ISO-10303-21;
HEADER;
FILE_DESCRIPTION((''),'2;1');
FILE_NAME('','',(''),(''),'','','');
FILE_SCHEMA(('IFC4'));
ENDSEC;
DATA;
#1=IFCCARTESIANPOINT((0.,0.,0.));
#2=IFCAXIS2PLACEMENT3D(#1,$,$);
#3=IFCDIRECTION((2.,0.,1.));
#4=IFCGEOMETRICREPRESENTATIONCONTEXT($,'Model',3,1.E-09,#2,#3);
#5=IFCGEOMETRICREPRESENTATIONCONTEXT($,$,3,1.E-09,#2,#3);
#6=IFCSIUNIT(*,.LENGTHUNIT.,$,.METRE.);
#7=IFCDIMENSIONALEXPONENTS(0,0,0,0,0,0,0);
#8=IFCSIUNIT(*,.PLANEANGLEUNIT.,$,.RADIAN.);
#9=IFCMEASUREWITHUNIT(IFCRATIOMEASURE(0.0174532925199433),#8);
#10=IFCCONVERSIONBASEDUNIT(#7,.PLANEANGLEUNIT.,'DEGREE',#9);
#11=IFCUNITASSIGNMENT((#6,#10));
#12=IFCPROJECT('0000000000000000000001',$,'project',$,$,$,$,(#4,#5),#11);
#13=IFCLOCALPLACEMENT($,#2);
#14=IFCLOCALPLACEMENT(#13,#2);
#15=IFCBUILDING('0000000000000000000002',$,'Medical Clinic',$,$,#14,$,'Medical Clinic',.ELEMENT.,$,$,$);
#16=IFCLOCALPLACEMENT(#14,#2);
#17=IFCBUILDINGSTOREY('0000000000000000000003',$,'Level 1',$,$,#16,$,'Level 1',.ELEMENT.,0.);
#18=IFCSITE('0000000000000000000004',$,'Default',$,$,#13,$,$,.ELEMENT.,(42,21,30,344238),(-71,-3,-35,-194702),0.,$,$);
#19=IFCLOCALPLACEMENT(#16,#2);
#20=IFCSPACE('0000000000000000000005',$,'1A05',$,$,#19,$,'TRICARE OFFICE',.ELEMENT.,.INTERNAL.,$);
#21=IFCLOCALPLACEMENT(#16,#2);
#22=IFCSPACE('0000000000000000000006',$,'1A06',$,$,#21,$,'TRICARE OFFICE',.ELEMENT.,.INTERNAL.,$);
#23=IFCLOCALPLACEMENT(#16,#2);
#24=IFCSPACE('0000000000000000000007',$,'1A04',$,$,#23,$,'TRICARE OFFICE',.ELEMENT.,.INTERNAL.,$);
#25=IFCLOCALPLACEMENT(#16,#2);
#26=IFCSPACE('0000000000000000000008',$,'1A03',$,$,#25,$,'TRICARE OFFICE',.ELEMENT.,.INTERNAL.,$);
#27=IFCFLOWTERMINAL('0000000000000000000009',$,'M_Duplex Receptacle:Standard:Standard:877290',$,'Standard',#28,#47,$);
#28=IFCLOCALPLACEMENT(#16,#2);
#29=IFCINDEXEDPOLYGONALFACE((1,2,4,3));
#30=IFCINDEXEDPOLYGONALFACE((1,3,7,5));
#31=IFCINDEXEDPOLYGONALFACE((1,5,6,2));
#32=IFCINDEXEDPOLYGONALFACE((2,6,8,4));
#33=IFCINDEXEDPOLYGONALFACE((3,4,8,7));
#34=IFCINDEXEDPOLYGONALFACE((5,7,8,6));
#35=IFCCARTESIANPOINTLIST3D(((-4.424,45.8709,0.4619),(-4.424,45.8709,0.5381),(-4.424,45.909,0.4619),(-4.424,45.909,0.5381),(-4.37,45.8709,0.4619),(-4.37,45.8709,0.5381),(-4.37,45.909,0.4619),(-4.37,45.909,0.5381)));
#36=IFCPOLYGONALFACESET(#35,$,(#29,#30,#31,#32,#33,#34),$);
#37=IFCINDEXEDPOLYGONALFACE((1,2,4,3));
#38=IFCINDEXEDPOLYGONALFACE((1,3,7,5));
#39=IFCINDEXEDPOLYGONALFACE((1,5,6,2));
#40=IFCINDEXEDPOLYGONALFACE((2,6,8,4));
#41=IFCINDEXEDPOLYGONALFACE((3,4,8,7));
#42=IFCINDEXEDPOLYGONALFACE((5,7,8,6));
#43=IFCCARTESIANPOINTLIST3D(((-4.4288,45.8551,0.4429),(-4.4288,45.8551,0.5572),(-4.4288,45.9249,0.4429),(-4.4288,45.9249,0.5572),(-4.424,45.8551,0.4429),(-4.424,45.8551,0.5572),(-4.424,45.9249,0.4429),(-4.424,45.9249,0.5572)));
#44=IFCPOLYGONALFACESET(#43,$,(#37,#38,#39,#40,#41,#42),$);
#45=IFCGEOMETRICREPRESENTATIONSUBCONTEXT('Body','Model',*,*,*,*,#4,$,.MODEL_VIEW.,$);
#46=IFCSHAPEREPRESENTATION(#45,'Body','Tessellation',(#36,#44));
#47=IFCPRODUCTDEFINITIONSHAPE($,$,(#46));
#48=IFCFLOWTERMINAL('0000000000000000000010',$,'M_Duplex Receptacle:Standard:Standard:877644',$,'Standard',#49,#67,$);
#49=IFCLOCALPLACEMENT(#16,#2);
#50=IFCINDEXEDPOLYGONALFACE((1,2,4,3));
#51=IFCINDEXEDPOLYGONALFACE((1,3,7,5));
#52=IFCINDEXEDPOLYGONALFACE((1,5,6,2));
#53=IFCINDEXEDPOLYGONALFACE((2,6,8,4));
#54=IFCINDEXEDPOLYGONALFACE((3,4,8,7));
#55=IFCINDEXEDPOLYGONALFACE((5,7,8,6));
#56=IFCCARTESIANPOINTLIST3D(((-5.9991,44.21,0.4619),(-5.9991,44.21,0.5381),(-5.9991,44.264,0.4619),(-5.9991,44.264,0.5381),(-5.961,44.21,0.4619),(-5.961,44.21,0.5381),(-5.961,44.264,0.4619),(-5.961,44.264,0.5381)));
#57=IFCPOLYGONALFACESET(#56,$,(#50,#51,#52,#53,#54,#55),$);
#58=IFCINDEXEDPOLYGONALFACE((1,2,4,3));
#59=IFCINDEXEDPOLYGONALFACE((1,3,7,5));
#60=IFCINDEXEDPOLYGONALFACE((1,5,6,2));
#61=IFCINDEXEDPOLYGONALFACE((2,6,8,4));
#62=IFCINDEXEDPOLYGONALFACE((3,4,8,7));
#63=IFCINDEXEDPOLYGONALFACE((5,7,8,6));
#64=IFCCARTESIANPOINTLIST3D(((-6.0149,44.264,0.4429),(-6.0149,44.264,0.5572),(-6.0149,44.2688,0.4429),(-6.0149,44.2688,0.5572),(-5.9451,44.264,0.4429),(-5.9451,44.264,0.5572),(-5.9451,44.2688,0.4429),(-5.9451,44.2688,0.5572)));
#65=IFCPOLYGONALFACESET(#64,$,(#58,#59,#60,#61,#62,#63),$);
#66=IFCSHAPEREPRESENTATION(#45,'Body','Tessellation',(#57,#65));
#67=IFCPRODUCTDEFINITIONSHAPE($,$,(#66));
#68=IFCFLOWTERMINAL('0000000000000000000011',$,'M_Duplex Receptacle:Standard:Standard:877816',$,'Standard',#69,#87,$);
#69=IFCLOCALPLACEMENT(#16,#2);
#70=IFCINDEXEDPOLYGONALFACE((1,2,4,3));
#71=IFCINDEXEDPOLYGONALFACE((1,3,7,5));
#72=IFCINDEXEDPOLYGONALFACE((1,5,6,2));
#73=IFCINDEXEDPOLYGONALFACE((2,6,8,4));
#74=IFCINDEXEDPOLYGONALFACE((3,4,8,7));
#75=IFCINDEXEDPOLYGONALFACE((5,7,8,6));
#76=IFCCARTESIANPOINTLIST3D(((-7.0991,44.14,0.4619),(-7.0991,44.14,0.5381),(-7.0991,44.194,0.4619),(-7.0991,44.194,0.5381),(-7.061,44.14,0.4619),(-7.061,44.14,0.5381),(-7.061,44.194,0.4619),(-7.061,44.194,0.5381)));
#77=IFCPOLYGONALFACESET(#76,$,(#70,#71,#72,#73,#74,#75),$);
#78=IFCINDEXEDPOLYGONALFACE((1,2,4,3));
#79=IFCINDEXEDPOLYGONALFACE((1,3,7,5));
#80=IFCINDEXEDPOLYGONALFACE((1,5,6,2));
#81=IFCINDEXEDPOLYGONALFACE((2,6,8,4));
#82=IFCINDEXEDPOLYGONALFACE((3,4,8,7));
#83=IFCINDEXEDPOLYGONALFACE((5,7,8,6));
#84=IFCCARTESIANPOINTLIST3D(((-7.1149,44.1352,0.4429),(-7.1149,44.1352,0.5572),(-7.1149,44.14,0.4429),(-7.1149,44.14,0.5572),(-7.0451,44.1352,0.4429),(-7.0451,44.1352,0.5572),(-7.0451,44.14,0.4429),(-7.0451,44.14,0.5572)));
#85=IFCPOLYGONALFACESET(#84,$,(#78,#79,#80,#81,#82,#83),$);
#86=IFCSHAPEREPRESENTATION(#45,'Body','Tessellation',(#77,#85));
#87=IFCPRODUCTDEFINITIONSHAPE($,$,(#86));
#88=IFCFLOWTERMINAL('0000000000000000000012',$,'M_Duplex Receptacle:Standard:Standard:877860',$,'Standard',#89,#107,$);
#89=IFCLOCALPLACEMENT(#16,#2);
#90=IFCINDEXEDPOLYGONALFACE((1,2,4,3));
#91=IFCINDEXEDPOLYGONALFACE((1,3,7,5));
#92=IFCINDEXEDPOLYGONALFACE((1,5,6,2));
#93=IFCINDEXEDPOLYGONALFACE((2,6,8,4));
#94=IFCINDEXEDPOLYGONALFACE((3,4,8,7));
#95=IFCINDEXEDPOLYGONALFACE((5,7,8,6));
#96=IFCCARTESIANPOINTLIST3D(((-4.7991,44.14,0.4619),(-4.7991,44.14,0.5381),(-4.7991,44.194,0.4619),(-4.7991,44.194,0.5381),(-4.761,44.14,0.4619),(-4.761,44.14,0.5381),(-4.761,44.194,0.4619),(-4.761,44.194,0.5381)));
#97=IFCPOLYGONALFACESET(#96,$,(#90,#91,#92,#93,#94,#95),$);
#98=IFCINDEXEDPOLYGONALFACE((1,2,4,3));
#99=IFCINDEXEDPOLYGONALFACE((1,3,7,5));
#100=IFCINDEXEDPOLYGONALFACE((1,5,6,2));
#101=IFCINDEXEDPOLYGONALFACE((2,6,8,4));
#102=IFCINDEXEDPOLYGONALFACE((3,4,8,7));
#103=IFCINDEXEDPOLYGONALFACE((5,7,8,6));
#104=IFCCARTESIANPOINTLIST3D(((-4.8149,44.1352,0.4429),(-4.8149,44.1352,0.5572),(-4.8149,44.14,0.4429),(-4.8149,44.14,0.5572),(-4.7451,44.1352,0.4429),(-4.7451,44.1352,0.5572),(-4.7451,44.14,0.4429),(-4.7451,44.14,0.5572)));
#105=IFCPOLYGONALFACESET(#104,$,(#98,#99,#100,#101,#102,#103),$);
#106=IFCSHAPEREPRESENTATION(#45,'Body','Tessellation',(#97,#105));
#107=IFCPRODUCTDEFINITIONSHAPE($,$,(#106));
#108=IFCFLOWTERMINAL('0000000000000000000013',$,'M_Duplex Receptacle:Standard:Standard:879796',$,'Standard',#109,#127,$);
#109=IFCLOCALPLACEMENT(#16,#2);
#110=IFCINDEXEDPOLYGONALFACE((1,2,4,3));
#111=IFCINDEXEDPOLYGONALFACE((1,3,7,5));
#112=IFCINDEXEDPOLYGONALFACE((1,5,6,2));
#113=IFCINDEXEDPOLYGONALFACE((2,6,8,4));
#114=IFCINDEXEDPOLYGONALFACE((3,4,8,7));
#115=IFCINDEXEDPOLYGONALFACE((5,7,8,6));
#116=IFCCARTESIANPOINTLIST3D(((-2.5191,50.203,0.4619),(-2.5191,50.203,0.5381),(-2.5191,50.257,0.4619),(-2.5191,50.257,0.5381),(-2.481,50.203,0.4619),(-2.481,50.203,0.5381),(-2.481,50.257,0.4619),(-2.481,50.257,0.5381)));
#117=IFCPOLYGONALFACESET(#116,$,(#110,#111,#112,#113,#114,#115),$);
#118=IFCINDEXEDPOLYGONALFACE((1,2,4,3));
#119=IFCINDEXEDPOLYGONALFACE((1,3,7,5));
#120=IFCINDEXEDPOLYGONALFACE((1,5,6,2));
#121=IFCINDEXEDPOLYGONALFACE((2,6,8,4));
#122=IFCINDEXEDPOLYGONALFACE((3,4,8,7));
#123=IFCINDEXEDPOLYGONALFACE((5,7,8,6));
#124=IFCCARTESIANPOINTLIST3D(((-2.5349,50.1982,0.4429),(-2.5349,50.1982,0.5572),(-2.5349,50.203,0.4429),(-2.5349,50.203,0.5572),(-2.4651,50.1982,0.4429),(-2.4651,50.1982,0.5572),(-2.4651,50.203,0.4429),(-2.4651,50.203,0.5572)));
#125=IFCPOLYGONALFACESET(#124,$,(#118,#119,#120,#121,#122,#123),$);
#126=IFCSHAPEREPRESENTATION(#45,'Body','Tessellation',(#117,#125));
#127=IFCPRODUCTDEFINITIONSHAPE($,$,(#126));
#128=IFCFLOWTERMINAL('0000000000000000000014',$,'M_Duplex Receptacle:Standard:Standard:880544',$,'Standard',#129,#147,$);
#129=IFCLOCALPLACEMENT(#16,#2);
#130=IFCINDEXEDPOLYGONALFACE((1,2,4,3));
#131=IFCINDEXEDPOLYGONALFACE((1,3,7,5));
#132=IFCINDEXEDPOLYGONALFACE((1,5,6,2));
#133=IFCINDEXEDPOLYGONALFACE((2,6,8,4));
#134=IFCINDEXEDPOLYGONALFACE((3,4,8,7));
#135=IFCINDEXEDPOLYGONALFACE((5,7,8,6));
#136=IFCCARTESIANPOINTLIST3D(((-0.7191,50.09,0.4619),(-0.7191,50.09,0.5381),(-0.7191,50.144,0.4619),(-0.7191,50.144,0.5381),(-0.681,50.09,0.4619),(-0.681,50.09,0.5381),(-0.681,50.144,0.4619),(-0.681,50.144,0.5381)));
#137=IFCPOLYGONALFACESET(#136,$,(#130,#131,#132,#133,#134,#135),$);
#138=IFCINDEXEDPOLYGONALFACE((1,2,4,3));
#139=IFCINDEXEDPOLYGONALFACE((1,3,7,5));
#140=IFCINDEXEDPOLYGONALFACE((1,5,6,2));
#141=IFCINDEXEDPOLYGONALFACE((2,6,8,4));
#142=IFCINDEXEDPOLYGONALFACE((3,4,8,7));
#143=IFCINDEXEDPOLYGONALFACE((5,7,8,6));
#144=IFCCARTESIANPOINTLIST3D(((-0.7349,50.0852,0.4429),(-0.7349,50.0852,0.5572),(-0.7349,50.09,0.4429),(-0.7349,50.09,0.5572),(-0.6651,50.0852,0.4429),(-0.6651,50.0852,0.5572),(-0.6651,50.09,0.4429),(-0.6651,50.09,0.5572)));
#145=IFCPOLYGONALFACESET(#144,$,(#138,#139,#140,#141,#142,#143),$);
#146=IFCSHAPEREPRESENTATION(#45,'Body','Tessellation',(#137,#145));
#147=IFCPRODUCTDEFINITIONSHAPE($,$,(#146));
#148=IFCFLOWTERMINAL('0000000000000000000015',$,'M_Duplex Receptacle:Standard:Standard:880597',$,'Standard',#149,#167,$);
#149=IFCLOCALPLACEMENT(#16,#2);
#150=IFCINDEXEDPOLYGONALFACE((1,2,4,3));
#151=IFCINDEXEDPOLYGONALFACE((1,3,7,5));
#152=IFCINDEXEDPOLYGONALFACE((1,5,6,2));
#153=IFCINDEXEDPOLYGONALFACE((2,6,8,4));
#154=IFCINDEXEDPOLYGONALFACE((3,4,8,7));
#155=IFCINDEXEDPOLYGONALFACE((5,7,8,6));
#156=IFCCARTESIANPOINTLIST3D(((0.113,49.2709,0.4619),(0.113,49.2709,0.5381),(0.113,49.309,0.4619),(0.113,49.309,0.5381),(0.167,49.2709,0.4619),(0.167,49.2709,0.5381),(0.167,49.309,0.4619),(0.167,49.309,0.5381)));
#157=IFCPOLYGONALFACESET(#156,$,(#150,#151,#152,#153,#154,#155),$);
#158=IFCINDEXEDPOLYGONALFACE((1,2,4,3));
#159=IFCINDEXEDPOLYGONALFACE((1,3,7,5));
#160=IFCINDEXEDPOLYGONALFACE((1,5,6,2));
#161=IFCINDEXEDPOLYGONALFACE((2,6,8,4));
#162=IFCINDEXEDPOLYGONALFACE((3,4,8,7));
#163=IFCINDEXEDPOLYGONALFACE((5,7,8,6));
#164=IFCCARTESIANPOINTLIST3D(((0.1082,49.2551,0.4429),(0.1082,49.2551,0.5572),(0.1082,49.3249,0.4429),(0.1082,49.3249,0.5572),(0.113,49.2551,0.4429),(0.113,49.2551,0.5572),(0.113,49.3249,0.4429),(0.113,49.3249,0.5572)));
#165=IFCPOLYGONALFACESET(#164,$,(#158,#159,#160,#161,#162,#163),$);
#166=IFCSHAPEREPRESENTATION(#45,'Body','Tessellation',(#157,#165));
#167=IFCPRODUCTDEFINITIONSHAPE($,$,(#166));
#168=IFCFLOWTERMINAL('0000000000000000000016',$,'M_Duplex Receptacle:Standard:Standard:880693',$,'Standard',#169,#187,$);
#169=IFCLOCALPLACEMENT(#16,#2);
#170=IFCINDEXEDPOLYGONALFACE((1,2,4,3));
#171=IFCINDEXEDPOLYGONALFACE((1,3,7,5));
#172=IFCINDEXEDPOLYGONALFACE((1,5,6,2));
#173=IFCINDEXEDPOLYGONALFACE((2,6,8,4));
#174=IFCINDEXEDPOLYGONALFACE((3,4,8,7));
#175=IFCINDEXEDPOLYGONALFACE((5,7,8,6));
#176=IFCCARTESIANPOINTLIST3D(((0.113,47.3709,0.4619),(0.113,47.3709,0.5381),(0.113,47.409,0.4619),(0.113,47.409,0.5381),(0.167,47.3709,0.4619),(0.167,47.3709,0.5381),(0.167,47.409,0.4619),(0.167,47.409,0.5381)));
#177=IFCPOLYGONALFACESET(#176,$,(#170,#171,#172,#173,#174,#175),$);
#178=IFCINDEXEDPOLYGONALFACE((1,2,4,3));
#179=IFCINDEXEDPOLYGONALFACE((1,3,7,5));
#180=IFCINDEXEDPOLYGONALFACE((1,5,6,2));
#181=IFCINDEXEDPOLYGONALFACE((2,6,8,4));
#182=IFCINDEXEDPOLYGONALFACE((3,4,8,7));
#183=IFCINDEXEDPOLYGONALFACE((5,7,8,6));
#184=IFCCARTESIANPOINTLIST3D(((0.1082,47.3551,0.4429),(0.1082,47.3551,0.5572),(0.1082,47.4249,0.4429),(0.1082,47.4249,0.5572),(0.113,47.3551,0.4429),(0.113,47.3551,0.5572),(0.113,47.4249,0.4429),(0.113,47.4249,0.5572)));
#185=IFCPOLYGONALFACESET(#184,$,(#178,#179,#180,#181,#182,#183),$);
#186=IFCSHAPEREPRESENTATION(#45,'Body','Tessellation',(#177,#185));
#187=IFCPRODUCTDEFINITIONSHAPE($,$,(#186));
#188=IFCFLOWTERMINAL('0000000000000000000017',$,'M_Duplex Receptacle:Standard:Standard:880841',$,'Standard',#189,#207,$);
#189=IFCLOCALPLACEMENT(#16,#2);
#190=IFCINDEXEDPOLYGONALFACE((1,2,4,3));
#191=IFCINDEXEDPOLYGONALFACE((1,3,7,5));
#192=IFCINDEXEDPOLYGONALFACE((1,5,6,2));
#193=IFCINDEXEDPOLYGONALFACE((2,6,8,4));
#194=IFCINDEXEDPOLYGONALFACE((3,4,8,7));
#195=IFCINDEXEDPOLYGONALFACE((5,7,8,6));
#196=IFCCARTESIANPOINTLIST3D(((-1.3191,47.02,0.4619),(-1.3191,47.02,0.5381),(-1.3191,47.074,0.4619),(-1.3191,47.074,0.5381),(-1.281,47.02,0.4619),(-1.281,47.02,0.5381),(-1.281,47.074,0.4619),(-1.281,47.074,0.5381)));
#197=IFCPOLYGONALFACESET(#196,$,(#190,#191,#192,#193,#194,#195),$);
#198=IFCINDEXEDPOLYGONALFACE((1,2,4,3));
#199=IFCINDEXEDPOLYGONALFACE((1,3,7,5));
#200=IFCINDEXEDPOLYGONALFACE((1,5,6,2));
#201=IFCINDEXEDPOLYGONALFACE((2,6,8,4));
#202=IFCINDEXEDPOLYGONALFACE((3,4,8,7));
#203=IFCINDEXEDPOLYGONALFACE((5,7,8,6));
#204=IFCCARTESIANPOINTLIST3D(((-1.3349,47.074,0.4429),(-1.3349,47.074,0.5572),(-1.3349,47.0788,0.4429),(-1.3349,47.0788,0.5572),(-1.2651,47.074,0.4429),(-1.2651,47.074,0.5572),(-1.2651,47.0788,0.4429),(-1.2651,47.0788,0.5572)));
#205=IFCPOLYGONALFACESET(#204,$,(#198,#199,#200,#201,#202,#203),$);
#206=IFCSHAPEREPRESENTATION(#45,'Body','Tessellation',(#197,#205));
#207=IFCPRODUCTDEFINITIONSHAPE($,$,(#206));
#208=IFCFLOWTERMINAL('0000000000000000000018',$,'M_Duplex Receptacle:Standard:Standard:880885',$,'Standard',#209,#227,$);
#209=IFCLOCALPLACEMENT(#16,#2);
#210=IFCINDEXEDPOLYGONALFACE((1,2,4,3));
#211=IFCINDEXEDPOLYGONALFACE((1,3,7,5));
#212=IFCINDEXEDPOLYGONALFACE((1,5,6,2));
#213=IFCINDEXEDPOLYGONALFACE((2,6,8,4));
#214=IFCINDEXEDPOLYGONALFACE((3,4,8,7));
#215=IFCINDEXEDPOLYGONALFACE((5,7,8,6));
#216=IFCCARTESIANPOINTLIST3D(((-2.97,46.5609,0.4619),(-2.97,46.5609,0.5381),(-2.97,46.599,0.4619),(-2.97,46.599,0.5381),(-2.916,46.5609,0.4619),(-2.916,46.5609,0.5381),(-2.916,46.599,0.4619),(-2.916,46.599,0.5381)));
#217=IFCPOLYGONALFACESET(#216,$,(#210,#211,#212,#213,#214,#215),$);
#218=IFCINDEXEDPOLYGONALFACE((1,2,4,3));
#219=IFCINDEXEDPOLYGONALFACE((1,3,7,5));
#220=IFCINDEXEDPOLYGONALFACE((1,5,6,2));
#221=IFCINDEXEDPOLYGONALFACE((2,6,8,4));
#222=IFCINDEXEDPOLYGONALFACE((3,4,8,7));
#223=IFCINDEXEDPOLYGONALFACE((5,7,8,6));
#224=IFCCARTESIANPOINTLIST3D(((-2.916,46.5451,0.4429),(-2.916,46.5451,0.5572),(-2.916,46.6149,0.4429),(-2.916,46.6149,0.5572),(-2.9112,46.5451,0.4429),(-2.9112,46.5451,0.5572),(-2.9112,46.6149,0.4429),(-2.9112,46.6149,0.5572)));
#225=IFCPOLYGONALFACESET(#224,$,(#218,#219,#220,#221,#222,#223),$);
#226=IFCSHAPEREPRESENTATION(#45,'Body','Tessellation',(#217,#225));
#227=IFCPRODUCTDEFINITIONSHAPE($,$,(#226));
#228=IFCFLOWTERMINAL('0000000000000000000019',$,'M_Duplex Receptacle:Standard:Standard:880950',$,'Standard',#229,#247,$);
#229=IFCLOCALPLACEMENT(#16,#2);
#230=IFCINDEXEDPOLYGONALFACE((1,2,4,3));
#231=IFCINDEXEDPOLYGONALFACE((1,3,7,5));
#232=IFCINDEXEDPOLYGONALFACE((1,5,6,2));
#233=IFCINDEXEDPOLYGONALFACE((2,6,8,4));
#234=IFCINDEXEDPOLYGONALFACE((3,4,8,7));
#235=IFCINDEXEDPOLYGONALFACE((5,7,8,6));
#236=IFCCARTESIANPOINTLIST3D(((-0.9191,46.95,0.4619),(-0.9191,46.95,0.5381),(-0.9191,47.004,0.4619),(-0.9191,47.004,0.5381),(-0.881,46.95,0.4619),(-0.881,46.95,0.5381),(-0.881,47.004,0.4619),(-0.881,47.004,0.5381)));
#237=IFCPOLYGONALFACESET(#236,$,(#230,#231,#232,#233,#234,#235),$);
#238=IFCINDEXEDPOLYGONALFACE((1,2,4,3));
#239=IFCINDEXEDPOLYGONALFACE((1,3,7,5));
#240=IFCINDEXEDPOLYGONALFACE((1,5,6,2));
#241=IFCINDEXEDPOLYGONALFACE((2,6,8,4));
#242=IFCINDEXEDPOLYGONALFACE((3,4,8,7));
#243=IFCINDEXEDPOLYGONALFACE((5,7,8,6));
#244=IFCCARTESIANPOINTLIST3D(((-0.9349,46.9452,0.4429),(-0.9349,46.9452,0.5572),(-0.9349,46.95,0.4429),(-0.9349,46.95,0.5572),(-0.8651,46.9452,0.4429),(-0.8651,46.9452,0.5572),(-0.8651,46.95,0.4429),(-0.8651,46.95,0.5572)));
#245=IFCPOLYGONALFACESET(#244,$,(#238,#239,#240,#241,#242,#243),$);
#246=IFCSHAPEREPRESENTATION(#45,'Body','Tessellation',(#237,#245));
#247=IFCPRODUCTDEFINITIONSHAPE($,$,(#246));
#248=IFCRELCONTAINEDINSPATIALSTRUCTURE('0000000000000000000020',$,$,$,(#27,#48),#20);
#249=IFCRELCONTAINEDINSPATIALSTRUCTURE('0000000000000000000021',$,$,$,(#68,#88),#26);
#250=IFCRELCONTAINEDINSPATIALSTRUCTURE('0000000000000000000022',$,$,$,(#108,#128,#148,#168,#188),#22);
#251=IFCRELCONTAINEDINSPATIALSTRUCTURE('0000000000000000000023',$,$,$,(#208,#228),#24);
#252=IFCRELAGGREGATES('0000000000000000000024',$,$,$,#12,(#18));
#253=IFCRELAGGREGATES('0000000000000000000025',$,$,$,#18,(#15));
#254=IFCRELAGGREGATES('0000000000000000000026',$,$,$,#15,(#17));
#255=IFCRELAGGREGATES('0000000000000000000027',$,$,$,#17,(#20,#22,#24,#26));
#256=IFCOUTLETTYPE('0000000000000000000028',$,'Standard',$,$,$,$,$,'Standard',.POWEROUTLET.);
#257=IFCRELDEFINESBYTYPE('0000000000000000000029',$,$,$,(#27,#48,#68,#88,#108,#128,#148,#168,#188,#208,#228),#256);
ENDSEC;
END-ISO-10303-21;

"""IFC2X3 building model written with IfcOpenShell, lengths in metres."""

from ifc_helpers import new_model, entity, si_unit, converted_unit, direction, frame, frame_2d, origin, origin_2d_with_axis, place, context, subcontext, project, spatial, rectangle, extrude, source, transform, mapped, type_object, type_shapes, element, save


model = new_model("IFC2X3")

# Units and contexts
model_context = context("Model", 3, precision=1e-09, world=origin(), true_north=direction((2.0, 0.0, 1.0)))
context_of_model = context(None, 3, precision=1e-09, world=origin(), true_north=direction((2.0, 0.0, 1.0)))
body_context = subcontext(model_context, "Body", "Model", "MODEL_VIEW")
ifc_project = project(units=[si_unit("LENGTHUNIT", "METRE"), converted_unit("PLANEANGLEUNIT", "DEGREE", entity("IfcRatioMeasure", 0.0174532925199433), si_unit("PLANEANGLEUNIT", "RADIAN"), dimensions=[0, 0, 0, 0, 0, 0, 0])], contexts=[model_context, context_of_model])

# Site, building, storey
site_placement = place(None, origin())
site = spatial("IfcSite", under=ifc_project, at=site_placement, Name="Default", CompositionType="ELEMENT", RefLatitude=(42, 21, 30, 344238), RefLongitude=(-71, -3, -35, -194702), RefElevation=0.0)
building_placement = place(site_placement, origin())
building = spatial("IfcBuilding", under=site, at=building_placement, Name="Medical Clinic", LongName="Medical Clinic", CompositionType="ELEMENT")
storey_placement = place(building_placement, origin())
storey = spatial("IfcBuildingStorey", under=building, at=storey_placement, Name="Level 1", LongName="Level 1", CompositionType="ELEMENT", Elevation=0.0)

# Shared definitions
space_1_placement = place(storey_placement, origin())
space_1 = spatial("IfcSpace", under=storey, at=space_1_placement, Name="1A05", LongName="TRICARE OFFICE", CompositionType="ELEMENT", InteriorOrExteriorSpace="INTERNAL")

# Shared definitions
space_2_placement = place(storey_placement, origin())
space_2 = spatial("IfcSpace", under=storey, at=space_2_placement, Name="1A06", LongName="TRICARE OFFICE", CompositionType="ELEMENT", InteriorOrExteriorSpace="INTERNAL")

# Shared definitions
space_3_placement = place(storey_placement, origin())
space_3 = spatial("IfcSpace", under=storey, at=space_3_placement, Name="1A04", LongName="TRICARE OFFICE", CompositionType="ELEMENT", InteriorOrExteriorSpace="INTERNAL")

# Flow terminals
outlet_type = type_object("IfcOutletType", Name="Standard", ElementType="Standard", PredefinedType="POWEROUTLET")
shared_shape_1 = source(origin(), body_context, "Body", "SweptSolid", [
    extrude(rectangle(XDim=0.0381, YDim=0.0762, at=origin_2d_with_axis()), frame((0.0, 0.0, -0.054), z_axis=(0.0, 0.0, 1.0), x_axis=(-1.0, 0.0, 0.0)), (0.0, 0.0, 1.0), 0.054),
    extrude(rectangle(XDim=0.0698, YDim=0.1143, at=frame_2d((0.0, 0.0), x_axis=(1.0, 0.0))), frame((0.0, 0.0, 0.0), z_axis=(0.0, 0.0, 1.0), x_axis=(-1.0, 0.0, 0.0)), (0.0, 0.0, 1.0), 0.0048),
])
type_shapes(outlet_type, [shared_shape_1])
for number, where, z_axis, x_axis, name in (
    (1, (-4.424, 45.89, 0.5), (-1.0, 0.0, 0.0), (0.0, -1.0, 0.0), "M_Duplex Receptacle:Standard:Standard:877290"),
    (2, (-5.98, 44.264, 0.5), (0.0, 1.0, 0.0), (-1.0, 0.0, 0.0), "M_Duplex Receptacle:Standard:Standard:877644"),
):
    element("IfcFlowTerminal", number, at=place(space_1_placement, frame(where, z_axis=z_axis, x_axis=x_axis)), inside=space_1, type_object=outlet_type, Name=name, ObjectType="Standard", context=body_context, shape_type="MappedRepresentation", body=[
        mapped(shared_shape_1, transform((0.0, 0.0, 0.0), scale=1.0)),
    ])

# Shared definitions
space_4_placement = place(storey_placement, origin())
space_4 = spatial("IfcSpace", under=storey, at=space_4_placement, Name="1A03", LongName="TRICARE OFFICE", CompositionType="ELEMENT", InteriorOrExteriorSpace="INTERNAL")

# Flow terminals
for number, where, z_axis, x_axis, name in (
    (3, (-7.08, 44.14, 0.5), (0.0, -1.0, 0.0), (1.0, 0.0, 0.0), "M_Duplex Receptacle:Standard:Standard:877816"),
    (4, (-4.78, 44.14, 0.5), (0.0, -1.0, 0.0), (1.0, 0.0, 0.0), "M_Duplex Receptacle:Standard:Standard:877860"),
):
    element("IfcFlowTerminal", number, at=place(space_4_placement, frame(where, z_axis=z_axis, x_axis=x_axis)), inside=space_4, type_object=outlet_type, Name=name, ObjectType="Standard", context=body_context, shape_type="MappedRepresentation", body=[
        mapped(shared_shape_1, transform((0.0, 0.0, 0.0), scale=1.0)),
    ])
for number, where, z_axis, x_axis, name in (
    (5, (-2.5, 50.203, 0.5), (0.0, -1.0, 0.0), (1.0, 0.0, 0.0), "M_Duplex Receptacle:Standard:Standard:879796"),
    (6, (-0.7, 50.09, 0.5), (0.0, -1.0, 0.0), (1.0, 0.0, 0.0), "M_Duplex Receptacle:Standard:Standard:880544"),
    (7, (0.113, 49.29, 0.5), (-1.0, 0.0, 0.0), (0.0, -1.0, 0.0), "M_Duplex Receptacle:Standard:Standard:880597"),
    (8, (0.113, 47.39, 0.5), (-1.0, 0.0, 0.0), (0.0, -1.0, 0.0), "M_Duplex Receptacle:Standard:Standard:880693"),
    (9, (-1.3, 47.074, 0.5), (0.0, 1.0, 0.0), (-1.0, 0.0, 0.0), "M_Duplex Receptacle:Standard:Standard:880841"),
):
    element("IfcFlowTerminal", number, at=place(space_2_placement, frame(where, z_axis=z_axis, x_axis=x_axis)), inside=space_2, type_object=outlet_type, Name=name, ObjectType="Standard", context=body_context, shape_type="MappedRepresentation", body=[
        mapped(shared_shape_1, transform((0.0, 0.0, 0.0), scale=1.0)),
    ])
for number, where, z_axis, x_axis, name in (
    (10, (-2.916, 46.58, 0.5), (1.0, 0.0, 0.0), (0.0, 1.0, 0.0), "M_Duplex Receptacle:Standard:Standard:880885"),
    (11, (-0.9, 46.95, 0.5), (0.0, -1.0, 0.0), (1.0, 0.0, 0.0), "M_Duplex Receptacle:Standard:Standard:880950"),
):
    element("IfcFlowTerminal", number, at=place(space_3_placement, frame(where, z_axis=z_axis, x_axis=x_axis)), inside=space_3, type_object=outlet_type, Name=name, ObjectType="Standard", context=body_context, shape_type="MappedRepresentation", body=[
        mapped(shared_shape_1, transform((0.0, 0.0, 0.0), scale=1.0)),
    ])

save(model, "model.ifc")
